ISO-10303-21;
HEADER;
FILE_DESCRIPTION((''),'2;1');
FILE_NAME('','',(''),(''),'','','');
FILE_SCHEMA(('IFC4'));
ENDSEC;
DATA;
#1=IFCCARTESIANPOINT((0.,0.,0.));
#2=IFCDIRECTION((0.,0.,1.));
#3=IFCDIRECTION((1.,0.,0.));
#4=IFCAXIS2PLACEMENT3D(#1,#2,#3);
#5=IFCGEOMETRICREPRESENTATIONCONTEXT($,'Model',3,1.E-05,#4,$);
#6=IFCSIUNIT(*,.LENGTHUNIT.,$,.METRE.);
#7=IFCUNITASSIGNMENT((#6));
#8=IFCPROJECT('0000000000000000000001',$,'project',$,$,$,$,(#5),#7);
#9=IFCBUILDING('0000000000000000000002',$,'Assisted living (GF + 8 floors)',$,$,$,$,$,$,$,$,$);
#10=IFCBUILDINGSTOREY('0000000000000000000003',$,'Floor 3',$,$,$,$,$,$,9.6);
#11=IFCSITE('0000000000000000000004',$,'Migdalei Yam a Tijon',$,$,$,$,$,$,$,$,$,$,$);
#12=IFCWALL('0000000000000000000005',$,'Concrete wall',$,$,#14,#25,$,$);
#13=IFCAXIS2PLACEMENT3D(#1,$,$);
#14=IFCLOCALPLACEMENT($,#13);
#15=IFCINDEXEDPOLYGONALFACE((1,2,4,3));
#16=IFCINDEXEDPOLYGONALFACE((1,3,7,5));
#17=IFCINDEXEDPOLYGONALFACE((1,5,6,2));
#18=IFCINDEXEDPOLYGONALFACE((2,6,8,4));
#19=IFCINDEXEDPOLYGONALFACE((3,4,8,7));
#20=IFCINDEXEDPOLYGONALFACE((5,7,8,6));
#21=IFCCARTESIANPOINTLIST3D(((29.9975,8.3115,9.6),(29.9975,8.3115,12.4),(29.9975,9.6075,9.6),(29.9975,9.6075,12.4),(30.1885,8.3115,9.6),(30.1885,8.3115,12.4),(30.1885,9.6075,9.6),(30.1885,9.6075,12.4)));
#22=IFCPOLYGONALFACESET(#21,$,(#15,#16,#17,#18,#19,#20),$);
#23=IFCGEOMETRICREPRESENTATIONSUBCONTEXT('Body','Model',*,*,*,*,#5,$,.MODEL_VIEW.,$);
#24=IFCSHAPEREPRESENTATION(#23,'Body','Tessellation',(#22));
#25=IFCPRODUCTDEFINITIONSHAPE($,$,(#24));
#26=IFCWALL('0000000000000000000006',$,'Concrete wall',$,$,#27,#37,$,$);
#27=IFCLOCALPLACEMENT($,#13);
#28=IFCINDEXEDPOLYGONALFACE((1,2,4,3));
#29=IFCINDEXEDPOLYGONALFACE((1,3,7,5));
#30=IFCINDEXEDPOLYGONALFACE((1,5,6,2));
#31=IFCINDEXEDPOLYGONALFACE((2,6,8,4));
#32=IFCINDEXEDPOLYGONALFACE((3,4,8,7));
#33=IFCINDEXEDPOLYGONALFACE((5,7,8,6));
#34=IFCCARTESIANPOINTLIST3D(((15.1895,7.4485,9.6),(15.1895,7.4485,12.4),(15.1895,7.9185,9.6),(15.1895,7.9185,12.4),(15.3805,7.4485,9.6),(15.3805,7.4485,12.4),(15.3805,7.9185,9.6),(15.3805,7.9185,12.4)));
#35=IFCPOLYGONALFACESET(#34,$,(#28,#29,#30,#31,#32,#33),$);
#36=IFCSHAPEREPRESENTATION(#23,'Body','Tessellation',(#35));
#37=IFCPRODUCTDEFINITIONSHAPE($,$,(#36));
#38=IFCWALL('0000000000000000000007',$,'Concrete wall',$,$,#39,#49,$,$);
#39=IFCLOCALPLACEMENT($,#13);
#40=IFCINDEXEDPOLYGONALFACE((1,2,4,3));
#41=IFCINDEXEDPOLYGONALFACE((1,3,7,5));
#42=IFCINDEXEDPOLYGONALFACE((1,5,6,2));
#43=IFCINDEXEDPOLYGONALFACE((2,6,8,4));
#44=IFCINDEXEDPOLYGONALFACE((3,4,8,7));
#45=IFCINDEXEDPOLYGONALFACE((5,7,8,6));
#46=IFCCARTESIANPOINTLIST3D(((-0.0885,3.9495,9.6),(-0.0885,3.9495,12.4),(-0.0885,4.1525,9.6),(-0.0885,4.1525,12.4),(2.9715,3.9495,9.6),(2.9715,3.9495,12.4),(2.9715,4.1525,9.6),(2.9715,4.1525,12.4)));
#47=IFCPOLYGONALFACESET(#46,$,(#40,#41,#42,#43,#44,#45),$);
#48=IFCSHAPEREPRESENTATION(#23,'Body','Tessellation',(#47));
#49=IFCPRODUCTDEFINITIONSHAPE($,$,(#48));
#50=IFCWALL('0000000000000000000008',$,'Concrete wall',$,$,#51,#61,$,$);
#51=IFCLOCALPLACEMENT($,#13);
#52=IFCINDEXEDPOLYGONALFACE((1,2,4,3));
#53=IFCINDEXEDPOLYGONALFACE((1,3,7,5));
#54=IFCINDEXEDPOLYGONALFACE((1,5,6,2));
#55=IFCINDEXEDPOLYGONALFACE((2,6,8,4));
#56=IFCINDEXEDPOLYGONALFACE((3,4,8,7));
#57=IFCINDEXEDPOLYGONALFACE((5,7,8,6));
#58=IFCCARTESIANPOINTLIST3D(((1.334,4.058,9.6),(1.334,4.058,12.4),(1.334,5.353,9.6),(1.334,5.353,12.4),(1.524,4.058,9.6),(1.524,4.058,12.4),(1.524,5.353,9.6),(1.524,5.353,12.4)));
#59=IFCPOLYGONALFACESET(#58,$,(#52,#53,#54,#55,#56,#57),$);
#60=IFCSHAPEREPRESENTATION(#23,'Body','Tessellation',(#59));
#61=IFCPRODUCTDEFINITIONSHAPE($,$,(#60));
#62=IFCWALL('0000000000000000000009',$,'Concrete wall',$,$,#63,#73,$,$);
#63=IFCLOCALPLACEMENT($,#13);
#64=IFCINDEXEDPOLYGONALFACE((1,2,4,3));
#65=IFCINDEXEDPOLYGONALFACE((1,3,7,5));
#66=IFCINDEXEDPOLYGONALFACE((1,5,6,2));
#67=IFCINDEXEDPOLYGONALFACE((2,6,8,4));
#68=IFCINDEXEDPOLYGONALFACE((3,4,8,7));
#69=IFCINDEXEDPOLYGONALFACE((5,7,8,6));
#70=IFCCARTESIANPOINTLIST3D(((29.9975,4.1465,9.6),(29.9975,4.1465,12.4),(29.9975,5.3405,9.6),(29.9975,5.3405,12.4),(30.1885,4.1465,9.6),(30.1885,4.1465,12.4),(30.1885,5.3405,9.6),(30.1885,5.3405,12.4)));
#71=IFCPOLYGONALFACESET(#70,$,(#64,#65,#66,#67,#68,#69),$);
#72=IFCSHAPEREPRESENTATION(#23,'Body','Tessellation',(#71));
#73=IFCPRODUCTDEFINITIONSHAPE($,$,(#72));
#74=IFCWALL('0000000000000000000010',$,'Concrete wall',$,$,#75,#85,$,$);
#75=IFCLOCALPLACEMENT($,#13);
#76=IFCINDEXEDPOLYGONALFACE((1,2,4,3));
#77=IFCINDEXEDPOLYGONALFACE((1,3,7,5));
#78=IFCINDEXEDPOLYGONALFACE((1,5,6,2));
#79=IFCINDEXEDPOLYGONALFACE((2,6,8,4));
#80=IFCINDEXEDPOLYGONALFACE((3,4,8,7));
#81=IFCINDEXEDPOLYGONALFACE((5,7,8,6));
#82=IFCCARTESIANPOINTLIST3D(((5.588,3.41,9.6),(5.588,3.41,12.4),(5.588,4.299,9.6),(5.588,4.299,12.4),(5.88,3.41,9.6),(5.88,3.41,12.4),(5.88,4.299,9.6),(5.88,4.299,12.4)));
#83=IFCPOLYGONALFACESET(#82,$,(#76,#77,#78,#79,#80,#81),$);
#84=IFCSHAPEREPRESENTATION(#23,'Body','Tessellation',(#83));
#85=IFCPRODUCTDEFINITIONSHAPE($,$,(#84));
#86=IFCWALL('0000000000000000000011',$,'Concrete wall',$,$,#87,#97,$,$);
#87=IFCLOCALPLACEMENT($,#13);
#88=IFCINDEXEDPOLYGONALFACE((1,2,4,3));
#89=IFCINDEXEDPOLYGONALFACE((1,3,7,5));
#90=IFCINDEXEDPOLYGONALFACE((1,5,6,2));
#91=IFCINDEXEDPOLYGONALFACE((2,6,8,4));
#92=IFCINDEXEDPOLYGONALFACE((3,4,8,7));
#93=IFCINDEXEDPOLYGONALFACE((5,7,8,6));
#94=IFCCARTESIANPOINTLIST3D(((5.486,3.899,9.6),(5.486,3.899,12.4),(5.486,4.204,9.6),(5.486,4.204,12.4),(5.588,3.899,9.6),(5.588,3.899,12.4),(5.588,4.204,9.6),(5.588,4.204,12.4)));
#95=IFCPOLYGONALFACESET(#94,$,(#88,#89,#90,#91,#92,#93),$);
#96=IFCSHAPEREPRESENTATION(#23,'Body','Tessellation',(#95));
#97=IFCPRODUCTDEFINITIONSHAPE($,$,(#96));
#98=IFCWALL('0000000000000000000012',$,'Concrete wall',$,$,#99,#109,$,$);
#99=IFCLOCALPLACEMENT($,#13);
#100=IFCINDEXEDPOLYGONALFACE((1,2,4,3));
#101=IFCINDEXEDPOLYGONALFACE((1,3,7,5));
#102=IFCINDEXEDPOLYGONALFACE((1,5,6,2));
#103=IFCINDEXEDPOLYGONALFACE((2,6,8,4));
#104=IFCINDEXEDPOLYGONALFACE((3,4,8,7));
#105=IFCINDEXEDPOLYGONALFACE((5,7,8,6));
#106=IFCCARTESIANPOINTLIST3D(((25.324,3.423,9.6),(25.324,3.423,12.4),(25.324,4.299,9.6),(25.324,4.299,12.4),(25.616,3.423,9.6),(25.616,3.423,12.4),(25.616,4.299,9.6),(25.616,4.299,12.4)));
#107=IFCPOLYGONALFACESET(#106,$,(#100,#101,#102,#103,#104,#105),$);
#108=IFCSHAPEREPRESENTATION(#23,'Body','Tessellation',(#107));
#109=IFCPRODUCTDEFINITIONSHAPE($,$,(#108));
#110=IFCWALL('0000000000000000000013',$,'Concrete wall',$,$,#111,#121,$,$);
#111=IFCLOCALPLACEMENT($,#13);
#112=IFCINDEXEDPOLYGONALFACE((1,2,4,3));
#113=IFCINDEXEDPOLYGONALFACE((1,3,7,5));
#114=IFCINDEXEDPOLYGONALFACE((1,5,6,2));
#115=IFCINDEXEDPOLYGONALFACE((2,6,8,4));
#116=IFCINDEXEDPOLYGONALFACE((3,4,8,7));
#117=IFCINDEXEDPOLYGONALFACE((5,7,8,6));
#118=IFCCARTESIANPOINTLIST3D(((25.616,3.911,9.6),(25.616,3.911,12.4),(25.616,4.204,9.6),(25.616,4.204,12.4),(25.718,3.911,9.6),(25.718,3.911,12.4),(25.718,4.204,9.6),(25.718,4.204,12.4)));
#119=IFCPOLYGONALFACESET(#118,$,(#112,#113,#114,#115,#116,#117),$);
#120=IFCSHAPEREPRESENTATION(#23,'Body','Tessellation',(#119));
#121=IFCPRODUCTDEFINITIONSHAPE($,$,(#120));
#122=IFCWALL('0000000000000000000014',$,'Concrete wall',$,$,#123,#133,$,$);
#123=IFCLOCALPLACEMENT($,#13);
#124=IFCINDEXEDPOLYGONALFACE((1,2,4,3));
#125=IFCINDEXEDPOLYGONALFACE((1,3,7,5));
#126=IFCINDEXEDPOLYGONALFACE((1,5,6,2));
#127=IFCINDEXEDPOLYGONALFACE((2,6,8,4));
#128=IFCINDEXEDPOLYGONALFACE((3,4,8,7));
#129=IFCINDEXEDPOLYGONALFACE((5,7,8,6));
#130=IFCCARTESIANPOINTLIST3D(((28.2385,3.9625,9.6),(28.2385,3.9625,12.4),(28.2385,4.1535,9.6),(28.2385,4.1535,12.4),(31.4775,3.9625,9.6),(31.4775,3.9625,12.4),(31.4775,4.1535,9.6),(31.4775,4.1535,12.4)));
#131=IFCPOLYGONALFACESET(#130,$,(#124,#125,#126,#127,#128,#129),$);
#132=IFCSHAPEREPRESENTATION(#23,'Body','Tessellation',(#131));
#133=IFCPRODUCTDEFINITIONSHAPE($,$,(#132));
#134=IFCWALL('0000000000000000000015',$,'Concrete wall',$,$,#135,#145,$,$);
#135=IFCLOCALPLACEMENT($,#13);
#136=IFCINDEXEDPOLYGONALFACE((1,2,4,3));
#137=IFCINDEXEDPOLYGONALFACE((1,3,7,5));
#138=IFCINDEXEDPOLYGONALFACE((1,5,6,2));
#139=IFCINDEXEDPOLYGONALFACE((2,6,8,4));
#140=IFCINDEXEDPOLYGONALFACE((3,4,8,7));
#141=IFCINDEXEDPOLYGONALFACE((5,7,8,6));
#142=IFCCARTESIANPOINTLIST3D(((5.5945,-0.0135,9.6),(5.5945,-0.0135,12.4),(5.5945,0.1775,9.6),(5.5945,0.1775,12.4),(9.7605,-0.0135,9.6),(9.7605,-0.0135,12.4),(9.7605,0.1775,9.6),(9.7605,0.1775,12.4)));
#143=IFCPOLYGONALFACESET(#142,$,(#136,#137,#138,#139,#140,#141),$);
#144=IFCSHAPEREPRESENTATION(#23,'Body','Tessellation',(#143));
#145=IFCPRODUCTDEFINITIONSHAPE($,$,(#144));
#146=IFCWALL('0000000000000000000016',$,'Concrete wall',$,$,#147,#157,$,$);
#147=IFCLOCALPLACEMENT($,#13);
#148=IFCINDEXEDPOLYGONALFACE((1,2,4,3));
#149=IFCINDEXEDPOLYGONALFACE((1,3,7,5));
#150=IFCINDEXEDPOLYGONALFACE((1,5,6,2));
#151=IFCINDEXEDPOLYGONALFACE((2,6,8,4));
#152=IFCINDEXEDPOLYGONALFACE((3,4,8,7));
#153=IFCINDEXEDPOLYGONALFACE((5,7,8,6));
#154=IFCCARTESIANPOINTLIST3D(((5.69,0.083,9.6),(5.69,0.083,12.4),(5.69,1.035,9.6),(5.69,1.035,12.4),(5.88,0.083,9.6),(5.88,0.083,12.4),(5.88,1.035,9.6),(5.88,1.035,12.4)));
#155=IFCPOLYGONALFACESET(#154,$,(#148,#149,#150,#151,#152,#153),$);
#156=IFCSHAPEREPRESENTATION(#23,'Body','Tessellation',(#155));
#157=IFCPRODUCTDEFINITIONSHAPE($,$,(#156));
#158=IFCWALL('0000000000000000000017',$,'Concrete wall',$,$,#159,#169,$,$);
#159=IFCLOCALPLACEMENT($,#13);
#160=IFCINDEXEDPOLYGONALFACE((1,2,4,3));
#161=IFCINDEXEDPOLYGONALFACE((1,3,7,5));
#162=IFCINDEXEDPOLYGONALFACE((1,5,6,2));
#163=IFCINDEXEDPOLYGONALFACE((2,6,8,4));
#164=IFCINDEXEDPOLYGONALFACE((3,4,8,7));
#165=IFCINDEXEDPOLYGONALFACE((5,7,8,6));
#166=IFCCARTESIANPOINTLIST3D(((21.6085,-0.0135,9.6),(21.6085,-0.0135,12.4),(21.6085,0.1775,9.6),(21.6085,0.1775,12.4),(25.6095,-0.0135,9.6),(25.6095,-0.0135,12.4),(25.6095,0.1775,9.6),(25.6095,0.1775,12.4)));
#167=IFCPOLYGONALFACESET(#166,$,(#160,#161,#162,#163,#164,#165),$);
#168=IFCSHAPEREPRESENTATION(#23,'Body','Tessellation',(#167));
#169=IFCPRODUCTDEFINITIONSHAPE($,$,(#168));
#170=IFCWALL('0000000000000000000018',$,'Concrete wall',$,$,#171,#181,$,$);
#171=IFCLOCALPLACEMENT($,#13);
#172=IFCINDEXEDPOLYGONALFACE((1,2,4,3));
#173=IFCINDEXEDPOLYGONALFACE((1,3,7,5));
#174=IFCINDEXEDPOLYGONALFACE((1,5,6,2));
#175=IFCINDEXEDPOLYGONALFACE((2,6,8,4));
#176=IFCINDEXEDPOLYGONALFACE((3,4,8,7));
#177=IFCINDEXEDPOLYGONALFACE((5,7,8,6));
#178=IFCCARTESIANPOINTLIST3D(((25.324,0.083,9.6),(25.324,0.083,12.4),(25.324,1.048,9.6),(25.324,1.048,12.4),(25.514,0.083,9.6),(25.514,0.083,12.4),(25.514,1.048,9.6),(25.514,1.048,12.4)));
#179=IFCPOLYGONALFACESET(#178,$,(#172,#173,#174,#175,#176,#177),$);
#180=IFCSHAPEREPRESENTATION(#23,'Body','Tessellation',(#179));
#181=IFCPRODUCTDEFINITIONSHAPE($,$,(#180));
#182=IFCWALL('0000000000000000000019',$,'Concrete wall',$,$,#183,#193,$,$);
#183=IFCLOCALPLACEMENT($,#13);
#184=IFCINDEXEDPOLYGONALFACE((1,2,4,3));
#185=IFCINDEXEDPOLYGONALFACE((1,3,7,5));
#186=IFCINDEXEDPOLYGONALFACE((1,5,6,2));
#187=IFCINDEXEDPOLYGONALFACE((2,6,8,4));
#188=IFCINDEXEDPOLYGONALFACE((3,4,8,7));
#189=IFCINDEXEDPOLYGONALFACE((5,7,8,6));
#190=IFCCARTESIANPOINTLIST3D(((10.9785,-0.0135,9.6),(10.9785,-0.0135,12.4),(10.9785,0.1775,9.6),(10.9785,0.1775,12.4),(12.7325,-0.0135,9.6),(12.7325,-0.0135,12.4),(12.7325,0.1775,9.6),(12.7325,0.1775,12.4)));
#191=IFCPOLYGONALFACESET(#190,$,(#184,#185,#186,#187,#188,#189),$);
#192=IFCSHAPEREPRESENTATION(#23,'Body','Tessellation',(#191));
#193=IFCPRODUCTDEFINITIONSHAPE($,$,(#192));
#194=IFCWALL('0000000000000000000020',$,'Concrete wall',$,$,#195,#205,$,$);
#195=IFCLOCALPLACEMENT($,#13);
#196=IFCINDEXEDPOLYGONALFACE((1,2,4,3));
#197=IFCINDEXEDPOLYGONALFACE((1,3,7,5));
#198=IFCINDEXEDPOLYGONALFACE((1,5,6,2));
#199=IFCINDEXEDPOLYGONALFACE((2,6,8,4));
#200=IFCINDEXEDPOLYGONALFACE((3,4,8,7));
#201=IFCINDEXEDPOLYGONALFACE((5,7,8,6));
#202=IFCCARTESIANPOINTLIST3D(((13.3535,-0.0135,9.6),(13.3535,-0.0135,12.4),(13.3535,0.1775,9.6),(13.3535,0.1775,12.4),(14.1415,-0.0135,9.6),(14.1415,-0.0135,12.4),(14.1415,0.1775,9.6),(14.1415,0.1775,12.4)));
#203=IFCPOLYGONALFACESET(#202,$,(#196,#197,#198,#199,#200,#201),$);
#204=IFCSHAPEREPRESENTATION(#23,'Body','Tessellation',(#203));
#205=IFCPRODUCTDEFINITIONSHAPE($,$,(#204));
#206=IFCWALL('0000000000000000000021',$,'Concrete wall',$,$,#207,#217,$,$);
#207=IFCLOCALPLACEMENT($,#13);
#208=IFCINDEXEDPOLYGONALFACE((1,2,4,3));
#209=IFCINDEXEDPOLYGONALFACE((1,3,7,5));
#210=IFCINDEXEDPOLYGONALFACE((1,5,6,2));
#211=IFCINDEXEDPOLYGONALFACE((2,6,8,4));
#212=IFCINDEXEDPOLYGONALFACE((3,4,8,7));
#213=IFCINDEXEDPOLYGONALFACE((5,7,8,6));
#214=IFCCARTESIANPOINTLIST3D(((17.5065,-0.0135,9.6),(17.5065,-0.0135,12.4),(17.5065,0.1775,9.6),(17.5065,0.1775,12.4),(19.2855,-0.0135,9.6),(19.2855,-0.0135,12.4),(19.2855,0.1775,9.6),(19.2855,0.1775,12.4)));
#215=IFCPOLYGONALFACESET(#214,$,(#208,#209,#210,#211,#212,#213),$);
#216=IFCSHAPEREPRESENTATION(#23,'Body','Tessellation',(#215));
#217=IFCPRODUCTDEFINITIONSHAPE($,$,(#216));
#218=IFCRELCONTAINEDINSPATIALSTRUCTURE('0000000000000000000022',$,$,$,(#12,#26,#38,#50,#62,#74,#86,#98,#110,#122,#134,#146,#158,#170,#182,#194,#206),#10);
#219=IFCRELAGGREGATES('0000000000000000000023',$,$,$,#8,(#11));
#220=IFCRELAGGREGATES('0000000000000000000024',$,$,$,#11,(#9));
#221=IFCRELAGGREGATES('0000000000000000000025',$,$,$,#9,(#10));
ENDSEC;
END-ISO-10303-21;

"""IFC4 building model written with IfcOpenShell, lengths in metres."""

from ifc_helpers import new_model, si_unit, frame, origin_with_axes, context, subcontext, project, spatial, line, indexed_curve, outline, extrude, element, save


model = new_model("IFC4")

# Units and contexts
model_context = context("Model", 3, precision=1e-05, world=origin_with_axes())
body_context = subcontext(model_context, "Body", "Model", "MODEL_VIEW")
ifc_project = project(units=[si_unit("LENGTHUNIT", "METRE")], contexts=[model_context])

# Site, building, storey
site = spatial("IfcSite", under=ifc_project, Name="Migdalei Yam a Tijon")
building = spatial("IfcBuilding", under=site, Name="Assisted living (GF + 8 floors)")
storey = spatial("IfcBuildingStorey", under=building, Name="Floor 3", Elevation=9.6)

# Walls
element("IfcWall", 1, inside=storey, Name="Concrete wall", context=body_context, shape_type="SweptSolid", body=[
    extrude(outline(indexed_curve([(0.0, 0.0), (0.191, 0.0), (0.191, 1.296), (0.0, 1.296)], segments=[line(1, 2, 3, 4, 1)])), frame((29.9975, 8.3115, 9.6), z_axis=(0.0, 0.0, 1.0), x_axis=(1.0, 0.0, 0.0)), (0.0, 0.0, 1.0), 2.8),
])
element("IfcWall", 2, inside=storey, Name="Concrete wall", context=body_context, shape_type="SweptSolid", body=[
    extrude(outline(indexed_curve([(0.0, 0.0), (0.191, 0.0), (0.191, 0.47), (0.0, 0.47)], segments=[line(1, 2, 3, 4, 1)])), frame((15.1895, 7.4485, 9.6), z_axis=(0.0, 0.0, 1.0), x_axis=(1.0, 0.0, 0.0)), (0.0, 0.0, 1.0), 2.8),
])
element("IfcWall", 3, inside=storey, Name="Concrete wall", context=body_context, shape_type="SweptSolid", body=[
    extrude(outline(indexed_curve([(0.0, 0.0), (3.06, 0.0), (3.06, 0.203), (0.0, 0.203)], segments=[line(1, 2, 3, 4, 1)])), frame((-0.0885, 3.9495, 9.6), z_axis=(0.0, 0.0, 1.0), x_axis=(1.0, 0.0, 0.0)), (0.0, 0.0, 1.0), 2.8),
])
element("IfcWall", 4, inside=storey, Name="Concrete wall", context=body_context, shape_type="SweptSolid", body=[
    extrude(outline(indexed_curve([(0.0, 0.0), (0.19, 0.0), (0.19, 1.295), (0.0, 1.295)], segments=[line(1, 2, 3, 4, 1)])), frame((1.334, 4.058, 9.6), z_axis=(0.0, 0.0, 1.0), x_axis=(1.0, 0.0, 0.0)), (0.0, 0.0, 1.0), 2.8),
])
element("IfcWall", 5, inside=storey, Name="Concrete wall", context=body_context, shape_type="SweptSolid", body=[
    extrude(outline(indexed_curve([(0.0, 0.0), (0.191, 0.0), (0.191, 1.194), (0.0, 1.194)], segments=[line(1, 2, 3, 4, 1)])), frame((29.9975, 4.1465, 9.6), z_axis=(0.0, 0.0, 1.0), x_axis=(1.0, 0.0, 0.0)), (0.0, 0.0, 1.0), 2.8),
])
element("IfcWall", 6, inside=storey, Name="Concrete wall", context=body_context, shape_type="SweptSolid", body=[
    extrude(outline(indexed_curve([(0.0, 0.0), (0.292, 0.0), (0.292, 0.889), (0.0, 0.889)], segments=[line(1, 2, 3, 4, 1)])), frame((5.588, 3.41, 9.6), z_axis=(0.0, 0.0, 1.0), x_axis=(1.0, 0.0, 0.0)), (0.0, 0.0, 1.0), 2.8),
])
element("IfcWall", 7, inside=storey, Name="Concrete wall", context=body_context, shape_type="SweptSolid", body=[
    extrude(outline(indexed_curve([(0.0, 0.0), (0.102, 0.0), (0.102, 0.305), (0.0, 0.305)], segments=[line(1, 2, 3, 4, 1)])), frame((5.486, 3.899, 9.6), z_axis=(0.0, 0.0, 1.0), x_axis=(1.0, 0.0, 0.0)), (0.0, 0.0, 1.0), 2.8),
])
element("IfcWall", 8, inside=storey, Name="Concrete wall", context=body_context, shape_type="SweptSolid", body=[
    extrude(outline(indexed_curve([(0.0, 0.0), (0.292, 0.0), (0.292, 0.876), (0.0, 0.876)], segments=[line(1, 2, 3, 4, 1)])), frame((25.324, 3.423, 9.6), z_axis=(0.0, 0.0, 1.0), x_axis=(1.0, 0.0, 0.0)), (0.0, 0.0, 1.0), 2.8),
])
element("IfcWall", 9, inside=storey, Name="Concrete wall", context=body_context, shape_type="SweptSolid", body=[
    extrude(outline(indexed_curve([(0.0, 0.0), (0.102, 0.0), (0.102, 0.293), (0.0, 0.293)], segments=[line(1, 2, 3, 4, 1)])), frame((25.616, 3.911, 9.6), z_axis=(0.0, 0.0, 1.0), x_axis=(1.0, 0.0, 0.0)), (0.0, 0.0, 1.0), 2.8),
])
element("IfcWall", 10, inside=storey, Name="Concrete wall", context=body_context, shape_type="SweptSolid", body=[
    extrude(outline(indexed_curve([(0.0, 0.0), (3.239, 0.0), (3.239, 0.191), (0.0, 0.191)], segments=[line(1, 2, 3, 4, 1)])), frame((28.2385, 3.9625, 9.6), z_axis=(0.0, 0.0, 1.0), x_axis=(1.0, 0.0, 0.0)), (0.0, 0.0, 1.0), 2.8),
])
element("IfcWall", 11, inside=storey, Name="Concrete wall", context=body_context, shape_type="SweptSolid", body=[
    extrude(outline(indexed_curve([(0.0, 0.0), (4.166, 0.0), (4.166, 0.191), (0.0, 0.191)], segments=[line(1, 2, 3, 4, 1)])), frame((5.5945, -0.0135, 9.6), z_axis=(0.0, 0.0, 1.0), x_axis=(1.0, 0.0, 0.0)), (0.0, 0.0, 1.0), 2.8),
])
element("IfcWall", 12, inside=storey, Name="Concrete wall", context=body_context, shape_type="SweptSolid", body=[
    extrude(outline(indexed_curve([(0.0, 0.0), (0.19, 0.0), (0.19, 0.952), (0.0, 0.952)], segments=[line(1, 2, 3, 4, 1)])), frame((5.69, 0.083, 9.6), z_axis=(0.0, 0.0, 1.0), x_axis=(1.0, 0.0, 0.0)), (0.0, 0.0, 1.0), 2.8),
])
element("IfcWall", 13, inside=storey, Name="Concrete wall", context=body_context, shape_type="SweptSolid", body=[
    extrude(outline(indexed_curve([(0.0, 0.0), (4.001, 0.0), (4.001, 0.191), (0.0, 0.191)], segments=[line(1, 2, 3, 4, 1)])), frame((21.6085, -0.0135, 9.6), z_axis=(0.0, 0.0, 1.0), x_axis=(1.0, 0.0, 0.0)), (0.0, 0.0, 1.0), 2.8),
])
element("IfcWall", 14, inside=storey, Name="Concrete wall", context=body_context, shape_type="SweptSolid", body=[
    extrude(outline(indexed_curve([(0.0, 0.0), (0.19, 0.0), (0.19, 0.965), (0.0, 0.965)], segments=[line(1, 2, 3, 4, 1)])), frame((25.324, 0.083, 9.6), z_axis=(0.0, 0.0, 1.0), x_axis=(1.0, 0.0, 0.0)), (0.0, 0.0, 1.0), 2.8),
])
element("IfcWall", 15, inside=storey, Name="Concrete wall", context=body_context, shape_type="SweptSolid", body=[
    extrude(outline(indexed_curve([(0.0, 0.0), (1.754, 0.0), (1.754, 0.191), (0.0, 0.191)], segments=[line(1, 2, 3, 4, 1)])), frame((10.9785, -0.0135, 9.6), z_axis=(0.0, 0.0, 1.0), x_axis=(1.0, 0.0, 0.0)), (0.0, 0.0, 1.0), 2.8),
])
element("IfcWall", 16, inside=storey, Name="Concrete wall", context=body_context, shape_type="SweptSolid", body=[
    extrude(outline(indexed_curve([(0.0, 0.0), (0.788, 0.0), (0.788, 0.191), (0.0, 0.191)], segments=[line(1, 2, 3, 4, 1)])), frame((13.3535, -0.0135, 9.6), z_axis=(0.0, 0.0, 1.0), x_axis=(1.0, 0.0, 0.0)), (0.0, 0.0, 1.0), 2.8),
])
element("IfcWall", 17, inside=storey, Name="Concrete wall", context=body_context, shape_type="SweptSolid", body=[
    extrude(outline(indexed_curve([(0.0, 0.0), (1.779, 0.0), (1.779, 0.191), (0.0, 0.191)], segments=[line(1, 2, 3, 4, 1)])), frame((17.5065, -0.0135, 9.6), z_axis=(0.0, 0.0, 1.0), x_axis=(1.0, 0.0, 0.0)), (0.0, 0.0, 1.0), 2.8),
])

save(model, "model.ifc")
